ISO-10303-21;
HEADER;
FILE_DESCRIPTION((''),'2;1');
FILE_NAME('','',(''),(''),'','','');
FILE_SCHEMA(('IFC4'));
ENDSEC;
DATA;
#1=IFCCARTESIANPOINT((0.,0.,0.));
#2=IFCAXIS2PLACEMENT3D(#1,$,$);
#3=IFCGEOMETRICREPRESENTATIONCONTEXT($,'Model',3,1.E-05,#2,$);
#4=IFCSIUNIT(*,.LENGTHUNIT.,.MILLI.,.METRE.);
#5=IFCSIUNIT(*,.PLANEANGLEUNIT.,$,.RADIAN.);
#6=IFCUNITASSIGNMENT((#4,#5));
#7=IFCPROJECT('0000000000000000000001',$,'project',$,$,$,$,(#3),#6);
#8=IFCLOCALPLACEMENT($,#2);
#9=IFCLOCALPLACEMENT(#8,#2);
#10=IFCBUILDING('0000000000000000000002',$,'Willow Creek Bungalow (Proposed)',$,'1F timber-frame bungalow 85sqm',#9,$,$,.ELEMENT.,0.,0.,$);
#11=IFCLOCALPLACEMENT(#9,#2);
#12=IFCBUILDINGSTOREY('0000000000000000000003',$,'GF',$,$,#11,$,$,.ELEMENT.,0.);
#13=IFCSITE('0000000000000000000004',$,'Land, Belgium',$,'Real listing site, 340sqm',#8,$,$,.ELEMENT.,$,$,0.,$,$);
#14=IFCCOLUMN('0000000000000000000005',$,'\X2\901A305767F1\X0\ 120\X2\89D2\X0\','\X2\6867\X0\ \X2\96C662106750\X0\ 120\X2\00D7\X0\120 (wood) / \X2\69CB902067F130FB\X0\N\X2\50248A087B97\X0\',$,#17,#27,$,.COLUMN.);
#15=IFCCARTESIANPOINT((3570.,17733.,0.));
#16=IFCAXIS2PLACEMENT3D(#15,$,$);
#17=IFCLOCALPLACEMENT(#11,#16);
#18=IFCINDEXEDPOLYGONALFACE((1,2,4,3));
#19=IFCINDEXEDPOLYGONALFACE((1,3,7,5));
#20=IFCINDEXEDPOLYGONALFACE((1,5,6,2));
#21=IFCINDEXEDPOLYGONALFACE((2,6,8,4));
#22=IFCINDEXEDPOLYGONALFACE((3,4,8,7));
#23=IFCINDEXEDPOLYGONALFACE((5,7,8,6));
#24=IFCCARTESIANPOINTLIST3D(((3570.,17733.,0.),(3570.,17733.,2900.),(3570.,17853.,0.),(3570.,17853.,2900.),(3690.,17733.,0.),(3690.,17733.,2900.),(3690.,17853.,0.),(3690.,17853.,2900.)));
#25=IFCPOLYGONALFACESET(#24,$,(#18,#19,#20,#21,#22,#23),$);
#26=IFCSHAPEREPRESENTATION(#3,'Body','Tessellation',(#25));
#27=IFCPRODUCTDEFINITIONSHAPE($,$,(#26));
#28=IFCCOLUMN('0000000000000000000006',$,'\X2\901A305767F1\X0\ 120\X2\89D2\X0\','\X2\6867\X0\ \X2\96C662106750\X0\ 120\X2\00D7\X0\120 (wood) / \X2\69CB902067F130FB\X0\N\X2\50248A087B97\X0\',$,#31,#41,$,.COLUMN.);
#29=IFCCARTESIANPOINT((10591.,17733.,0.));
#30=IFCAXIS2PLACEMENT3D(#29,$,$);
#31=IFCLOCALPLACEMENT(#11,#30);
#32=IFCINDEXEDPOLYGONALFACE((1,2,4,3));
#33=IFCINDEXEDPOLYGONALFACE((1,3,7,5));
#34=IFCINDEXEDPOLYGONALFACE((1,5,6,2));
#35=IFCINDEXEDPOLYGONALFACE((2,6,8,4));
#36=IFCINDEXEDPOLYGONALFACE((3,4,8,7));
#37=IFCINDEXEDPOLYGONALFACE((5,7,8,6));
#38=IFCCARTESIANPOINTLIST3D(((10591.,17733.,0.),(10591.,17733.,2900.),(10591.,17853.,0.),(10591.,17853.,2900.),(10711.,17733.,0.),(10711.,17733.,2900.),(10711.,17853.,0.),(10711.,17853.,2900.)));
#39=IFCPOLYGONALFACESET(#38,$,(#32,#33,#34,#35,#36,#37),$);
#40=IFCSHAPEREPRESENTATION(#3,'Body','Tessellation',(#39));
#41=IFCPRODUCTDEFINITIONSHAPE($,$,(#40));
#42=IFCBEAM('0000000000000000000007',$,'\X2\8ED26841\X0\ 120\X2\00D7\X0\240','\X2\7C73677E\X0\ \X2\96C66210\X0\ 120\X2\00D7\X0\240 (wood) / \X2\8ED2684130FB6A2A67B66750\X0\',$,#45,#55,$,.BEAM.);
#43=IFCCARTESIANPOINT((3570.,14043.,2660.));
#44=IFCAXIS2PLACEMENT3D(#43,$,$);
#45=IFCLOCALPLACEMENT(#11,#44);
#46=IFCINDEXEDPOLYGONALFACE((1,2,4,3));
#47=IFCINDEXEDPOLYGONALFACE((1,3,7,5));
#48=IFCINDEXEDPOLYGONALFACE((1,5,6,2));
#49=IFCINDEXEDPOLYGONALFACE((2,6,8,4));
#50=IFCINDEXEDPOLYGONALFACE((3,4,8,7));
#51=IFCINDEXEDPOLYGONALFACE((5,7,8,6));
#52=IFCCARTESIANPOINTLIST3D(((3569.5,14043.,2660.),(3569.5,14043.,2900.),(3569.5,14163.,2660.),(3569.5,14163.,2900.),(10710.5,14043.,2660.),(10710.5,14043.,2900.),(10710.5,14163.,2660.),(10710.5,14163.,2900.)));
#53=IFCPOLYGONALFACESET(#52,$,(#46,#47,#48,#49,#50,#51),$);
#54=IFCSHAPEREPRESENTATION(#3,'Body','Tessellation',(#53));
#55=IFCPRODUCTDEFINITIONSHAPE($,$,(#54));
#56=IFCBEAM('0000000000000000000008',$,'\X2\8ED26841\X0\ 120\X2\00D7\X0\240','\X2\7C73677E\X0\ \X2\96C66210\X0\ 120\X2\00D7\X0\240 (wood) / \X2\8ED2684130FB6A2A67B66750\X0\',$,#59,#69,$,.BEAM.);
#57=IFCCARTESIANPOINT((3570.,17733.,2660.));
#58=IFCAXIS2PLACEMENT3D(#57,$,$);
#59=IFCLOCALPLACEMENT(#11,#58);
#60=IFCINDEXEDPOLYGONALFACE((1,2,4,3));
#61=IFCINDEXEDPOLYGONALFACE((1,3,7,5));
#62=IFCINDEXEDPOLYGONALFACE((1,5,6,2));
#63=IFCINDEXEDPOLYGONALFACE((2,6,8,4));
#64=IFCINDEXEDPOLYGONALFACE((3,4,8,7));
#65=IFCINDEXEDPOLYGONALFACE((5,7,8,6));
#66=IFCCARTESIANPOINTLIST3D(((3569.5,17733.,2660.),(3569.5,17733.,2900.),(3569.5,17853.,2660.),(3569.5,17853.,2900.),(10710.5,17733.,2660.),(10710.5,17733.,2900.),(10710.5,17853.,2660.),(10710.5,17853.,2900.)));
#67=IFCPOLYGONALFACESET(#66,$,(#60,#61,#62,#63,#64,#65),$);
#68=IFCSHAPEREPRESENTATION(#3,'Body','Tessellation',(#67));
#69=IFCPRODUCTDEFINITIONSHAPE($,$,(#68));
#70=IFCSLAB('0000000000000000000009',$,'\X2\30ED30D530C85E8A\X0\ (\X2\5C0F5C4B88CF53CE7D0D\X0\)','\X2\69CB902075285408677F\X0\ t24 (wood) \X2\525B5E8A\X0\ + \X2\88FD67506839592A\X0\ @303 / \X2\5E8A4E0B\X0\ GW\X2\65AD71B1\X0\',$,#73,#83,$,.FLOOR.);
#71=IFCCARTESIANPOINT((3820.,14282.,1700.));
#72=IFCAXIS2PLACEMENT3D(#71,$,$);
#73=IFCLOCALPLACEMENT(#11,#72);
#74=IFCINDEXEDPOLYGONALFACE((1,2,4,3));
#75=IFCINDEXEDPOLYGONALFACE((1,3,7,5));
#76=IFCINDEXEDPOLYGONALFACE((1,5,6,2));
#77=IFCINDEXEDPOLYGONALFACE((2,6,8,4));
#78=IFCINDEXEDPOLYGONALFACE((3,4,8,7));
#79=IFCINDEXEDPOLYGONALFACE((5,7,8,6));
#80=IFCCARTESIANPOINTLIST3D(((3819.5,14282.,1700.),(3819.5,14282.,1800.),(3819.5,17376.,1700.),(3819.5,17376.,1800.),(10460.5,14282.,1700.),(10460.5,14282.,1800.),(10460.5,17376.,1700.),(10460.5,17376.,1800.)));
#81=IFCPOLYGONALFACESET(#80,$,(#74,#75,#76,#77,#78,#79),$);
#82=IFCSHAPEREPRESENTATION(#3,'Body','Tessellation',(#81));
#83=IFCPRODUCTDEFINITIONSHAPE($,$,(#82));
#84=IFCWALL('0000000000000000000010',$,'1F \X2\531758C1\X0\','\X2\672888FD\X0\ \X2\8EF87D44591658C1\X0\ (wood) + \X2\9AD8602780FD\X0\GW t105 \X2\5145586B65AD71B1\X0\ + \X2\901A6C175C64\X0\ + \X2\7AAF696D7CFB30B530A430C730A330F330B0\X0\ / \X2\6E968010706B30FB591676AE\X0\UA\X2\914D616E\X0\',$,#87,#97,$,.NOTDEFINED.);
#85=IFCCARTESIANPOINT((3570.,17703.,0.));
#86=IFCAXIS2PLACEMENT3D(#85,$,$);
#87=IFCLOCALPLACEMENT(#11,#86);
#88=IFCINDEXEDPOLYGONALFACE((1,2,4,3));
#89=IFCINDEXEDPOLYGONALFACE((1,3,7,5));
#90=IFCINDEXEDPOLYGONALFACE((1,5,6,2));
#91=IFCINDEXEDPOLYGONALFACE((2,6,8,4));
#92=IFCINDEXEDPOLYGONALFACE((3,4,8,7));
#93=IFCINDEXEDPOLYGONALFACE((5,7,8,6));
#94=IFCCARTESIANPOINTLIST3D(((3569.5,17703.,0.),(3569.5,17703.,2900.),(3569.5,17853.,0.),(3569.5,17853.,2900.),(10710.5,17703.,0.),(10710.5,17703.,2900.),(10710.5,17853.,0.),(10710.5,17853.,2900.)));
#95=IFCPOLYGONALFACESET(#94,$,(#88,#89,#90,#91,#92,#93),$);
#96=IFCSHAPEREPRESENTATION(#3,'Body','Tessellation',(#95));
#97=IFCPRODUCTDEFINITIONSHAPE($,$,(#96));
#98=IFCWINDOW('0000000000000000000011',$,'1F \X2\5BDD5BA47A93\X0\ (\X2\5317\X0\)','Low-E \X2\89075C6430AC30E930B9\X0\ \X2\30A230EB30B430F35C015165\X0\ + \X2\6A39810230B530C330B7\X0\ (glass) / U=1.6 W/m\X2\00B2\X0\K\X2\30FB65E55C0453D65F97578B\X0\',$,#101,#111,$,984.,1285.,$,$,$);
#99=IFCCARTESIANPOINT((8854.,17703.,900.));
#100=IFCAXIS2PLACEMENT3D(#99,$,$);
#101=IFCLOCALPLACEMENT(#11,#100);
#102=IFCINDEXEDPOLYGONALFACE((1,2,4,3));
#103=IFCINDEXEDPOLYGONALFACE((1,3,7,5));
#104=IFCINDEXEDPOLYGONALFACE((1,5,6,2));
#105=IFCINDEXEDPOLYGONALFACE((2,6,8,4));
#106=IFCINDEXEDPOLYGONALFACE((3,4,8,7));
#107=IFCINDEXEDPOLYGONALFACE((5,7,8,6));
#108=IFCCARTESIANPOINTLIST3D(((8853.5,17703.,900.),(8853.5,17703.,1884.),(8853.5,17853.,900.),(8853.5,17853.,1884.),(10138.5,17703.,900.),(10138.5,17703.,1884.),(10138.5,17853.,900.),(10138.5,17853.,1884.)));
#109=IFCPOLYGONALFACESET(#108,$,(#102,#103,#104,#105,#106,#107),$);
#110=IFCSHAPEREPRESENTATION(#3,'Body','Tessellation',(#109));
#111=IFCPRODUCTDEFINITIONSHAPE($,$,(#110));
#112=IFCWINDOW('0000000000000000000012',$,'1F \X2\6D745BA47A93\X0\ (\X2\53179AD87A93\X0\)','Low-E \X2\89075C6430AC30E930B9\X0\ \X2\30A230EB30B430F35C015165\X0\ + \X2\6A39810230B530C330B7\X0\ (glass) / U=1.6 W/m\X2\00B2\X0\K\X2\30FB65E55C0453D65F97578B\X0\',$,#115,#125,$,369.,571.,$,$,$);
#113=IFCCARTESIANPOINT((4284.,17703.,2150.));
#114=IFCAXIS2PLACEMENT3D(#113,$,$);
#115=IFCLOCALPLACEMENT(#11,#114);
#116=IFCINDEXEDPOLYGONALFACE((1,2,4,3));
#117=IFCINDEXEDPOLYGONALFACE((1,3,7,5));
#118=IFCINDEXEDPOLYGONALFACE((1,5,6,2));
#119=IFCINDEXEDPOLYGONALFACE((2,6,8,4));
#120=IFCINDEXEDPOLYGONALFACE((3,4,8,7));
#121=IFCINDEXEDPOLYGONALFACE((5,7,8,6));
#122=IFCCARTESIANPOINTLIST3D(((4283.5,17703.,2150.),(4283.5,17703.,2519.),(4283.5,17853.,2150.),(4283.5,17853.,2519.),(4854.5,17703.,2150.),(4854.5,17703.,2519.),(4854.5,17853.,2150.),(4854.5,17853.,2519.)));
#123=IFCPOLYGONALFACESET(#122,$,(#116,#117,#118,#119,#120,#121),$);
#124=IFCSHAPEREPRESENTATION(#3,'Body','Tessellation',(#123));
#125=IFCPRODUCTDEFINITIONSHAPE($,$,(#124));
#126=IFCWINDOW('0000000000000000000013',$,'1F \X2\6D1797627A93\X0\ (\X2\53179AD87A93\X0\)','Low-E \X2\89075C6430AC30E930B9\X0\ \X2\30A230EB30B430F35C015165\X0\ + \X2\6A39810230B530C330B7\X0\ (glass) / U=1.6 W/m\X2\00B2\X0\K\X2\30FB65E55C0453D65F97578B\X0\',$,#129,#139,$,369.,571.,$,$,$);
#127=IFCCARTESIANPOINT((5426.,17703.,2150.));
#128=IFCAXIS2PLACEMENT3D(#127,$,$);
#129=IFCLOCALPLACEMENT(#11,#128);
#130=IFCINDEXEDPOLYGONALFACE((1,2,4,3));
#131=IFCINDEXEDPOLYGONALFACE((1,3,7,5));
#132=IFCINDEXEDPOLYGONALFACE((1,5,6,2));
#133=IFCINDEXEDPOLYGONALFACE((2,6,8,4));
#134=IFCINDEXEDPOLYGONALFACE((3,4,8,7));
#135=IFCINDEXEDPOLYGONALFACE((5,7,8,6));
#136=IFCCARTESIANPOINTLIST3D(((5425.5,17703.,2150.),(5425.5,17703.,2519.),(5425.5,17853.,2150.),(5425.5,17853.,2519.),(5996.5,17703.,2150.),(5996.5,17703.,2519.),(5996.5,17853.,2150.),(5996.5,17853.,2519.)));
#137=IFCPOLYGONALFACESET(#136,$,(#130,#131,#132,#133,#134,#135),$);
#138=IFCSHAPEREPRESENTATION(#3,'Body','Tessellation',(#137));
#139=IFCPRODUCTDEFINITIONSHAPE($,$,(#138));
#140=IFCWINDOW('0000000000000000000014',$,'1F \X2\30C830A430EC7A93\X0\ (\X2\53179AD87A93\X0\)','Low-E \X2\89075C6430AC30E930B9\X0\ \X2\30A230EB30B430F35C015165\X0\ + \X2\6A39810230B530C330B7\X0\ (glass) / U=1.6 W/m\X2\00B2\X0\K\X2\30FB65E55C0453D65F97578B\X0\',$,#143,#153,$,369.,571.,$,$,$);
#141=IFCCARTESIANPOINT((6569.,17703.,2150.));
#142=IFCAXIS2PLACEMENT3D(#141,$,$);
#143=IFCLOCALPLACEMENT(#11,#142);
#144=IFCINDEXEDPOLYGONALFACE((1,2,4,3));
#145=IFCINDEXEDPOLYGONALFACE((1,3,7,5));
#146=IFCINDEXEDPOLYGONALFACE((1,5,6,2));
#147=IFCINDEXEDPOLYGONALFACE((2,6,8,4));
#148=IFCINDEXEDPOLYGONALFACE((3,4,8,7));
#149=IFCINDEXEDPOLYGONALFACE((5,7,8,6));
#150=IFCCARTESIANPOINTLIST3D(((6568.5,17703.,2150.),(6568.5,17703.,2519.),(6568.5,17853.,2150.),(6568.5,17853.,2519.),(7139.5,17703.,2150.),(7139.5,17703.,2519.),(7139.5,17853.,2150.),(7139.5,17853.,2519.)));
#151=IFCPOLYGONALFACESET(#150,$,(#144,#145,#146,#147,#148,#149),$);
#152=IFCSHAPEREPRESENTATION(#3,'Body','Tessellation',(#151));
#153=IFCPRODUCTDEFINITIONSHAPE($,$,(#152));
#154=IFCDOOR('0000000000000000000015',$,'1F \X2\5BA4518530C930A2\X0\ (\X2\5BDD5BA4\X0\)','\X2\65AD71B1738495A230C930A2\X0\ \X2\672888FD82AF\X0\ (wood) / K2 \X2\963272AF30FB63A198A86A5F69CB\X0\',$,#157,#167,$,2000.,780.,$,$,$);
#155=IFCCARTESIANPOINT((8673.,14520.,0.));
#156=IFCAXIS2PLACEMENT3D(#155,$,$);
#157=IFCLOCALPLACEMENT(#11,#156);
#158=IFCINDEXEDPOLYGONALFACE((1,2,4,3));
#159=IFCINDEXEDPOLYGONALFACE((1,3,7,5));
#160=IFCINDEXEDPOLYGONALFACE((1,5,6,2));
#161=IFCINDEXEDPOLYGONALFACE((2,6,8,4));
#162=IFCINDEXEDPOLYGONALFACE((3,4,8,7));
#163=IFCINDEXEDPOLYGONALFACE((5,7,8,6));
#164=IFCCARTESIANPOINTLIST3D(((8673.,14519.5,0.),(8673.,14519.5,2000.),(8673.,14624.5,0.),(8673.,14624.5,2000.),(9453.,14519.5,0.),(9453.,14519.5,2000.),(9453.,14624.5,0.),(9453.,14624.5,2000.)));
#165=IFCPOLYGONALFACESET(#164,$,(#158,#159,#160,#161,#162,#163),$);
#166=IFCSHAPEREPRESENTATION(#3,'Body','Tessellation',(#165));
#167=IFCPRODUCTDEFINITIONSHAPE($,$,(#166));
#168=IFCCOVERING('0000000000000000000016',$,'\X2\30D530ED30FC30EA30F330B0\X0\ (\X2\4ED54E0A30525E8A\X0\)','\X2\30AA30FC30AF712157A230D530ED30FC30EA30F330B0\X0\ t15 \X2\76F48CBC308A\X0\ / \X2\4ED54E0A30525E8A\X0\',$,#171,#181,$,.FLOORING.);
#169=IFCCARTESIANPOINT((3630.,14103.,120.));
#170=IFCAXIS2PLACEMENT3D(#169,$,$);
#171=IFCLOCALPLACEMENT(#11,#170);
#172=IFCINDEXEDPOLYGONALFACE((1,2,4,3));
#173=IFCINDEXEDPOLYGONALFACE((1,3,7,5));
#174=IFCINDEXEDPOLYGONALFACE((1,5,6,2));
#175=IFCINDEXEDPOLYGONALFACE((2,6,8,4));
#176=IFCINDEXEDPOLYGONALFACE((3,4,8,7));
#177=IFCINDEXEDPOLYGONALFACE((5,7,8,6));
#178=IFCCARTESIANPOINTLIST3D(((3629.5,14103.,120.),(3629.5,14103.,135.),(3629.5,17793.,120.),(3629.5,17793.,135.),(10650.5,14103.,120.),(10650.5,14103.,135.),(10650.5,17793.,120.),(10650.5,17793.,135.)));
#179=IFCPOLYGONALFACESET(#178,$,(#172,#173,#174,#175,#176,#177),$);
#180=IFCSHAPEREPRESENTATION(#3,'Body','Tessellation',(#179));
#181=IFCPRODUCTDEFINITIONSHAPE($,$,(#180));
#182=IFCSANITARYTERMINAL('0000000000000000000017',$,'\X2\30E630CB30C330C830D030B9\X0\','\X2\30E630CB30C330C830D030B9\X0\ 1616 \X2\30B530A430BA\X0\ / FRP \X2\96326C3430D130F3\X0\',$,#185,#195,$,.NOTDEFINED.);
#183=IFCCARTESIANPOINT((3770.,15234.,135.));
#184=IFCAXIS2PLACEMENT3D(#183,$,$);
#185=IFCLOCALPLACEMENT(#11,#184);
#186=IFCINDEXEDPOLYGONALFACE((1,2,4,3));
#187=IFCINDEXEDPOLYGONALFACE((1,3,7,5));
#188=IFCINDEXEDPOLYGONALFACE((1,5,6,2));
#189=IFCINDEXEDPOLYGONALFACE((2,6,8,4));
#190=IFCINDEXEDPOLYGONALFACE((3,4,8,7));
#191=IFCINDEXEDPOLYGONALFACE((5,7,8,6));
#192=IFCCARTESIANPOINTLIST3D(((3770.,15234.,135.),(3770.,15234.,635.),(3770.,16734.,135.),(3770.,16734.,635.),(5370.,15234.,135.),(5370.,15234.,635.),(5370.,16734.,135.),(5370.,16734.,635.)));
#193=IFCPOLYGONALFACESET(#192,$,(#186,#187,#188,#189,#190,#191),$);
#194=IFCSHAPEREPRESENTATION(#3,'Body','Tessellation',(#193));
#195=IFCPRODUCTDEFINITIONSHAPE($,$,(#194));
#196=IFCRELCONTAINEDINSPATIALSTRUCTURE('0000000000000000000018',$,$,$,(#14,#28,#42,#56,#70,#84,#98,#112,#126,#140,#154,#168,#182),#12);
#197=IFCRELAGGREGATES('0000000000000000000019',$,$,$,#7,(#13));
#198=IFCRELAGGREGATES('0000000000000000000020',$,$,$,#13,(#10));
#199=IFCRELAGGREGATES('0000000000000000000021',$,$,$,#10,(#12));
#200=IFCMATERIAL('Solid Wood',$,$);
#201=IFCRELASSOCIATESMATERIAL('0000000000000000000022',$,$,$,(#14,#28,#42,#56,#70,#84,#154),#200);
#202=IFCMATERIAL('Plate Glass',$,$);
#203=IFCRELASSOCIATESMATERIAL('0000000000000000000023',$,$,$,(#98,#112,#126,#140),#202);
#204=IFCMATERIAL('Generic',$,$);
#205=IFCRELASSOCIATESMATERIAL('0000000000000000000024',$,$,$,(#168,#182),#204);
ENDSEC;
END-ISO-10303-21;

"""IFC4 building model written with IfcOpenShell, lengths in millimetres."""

from ifc_helpers import new_model, si_unit, frame, frame_2d, origin, place, context, project, spatial, rectangle, extrude, material, element, fill, save


model = new_model("IFC4")

# Units and contexts
model_context = context("Model", 3, precision=1e-05, world=origin())
ifc_project = project(units=[si_unit("LENGTHUNIT", "METRE", prefix="MILLI"), si_unit("PLANEANGLEUNIT", "RADIAN")], contexts=[model_context])

# Site, building, storey
site_placement = place(None, origin())
site = spatial("IfcSite", under=ifc_project, at=site_placement, Name="Land, Belgium", ObjectType="Real listing site, 340sqm", CompositionType="ELEMENT", RefElevation=0.0)
building_placement = place(site_placement, origin())
building = spatial("IfcBuilding", under=site, at=building_placement, Name="Willow Creek Bungalow (Proposed)", ObjectType="1F timber-frame bungalow 85sqm", CompositionType="ELEMENT", ElevationOfRefHeight=0.0, ElevationOfTerrain=0.0)
storey_placement = place(building_placement, origin())
storey = spatial("IfcBuildingStorey", under=building, at=storey_placement, Name="GF", CompositionType="ELEMENT", Elevation=0.0)

# Columns
ifc_material_1 = material(Name="Solid Wood")
column_1_placement = place(storey_placement, frame((3570.0, 17733.0, 0.0)))
element("IfcColumn", 1, at=column_1_placement, inside=storey, material=ifc_material_1, Name="通し柱 120角", Description="桧 集成材 120×120 (wood) / 構造柱・N値計算", PredefinedType="COLUMN", context=model_context, shape_type="SweptSolid", body=[
    extrude(rectangle(XDim=120.0, YDim=120.0, at=frame_2d((60.0, 60.0))), frame((3570.0, 17733.0, 0.0)), (0.0, 0.0, 1.0), 2900.0),
])
column_2_placement = place(storey_placement, frame((10591.0, 17733.0, 0.0)))
element("IfcColumn", 2, at=column_2_placement, inside=storey, material=ifc_material_1, Name="通し柱 120角", Description="桧 集成材 120×120 (wood) / 構造柱・N値計算", PredefinedType="COLUMN", context=model_context, shape_type="SweptSolid", body=[
    extrude(rectangle(XDim=120.0, YDim=120.0, at=frame_2d((60.0, 60.0))), frame((10591.0, 17733.0, 0.0)), (0.0, 0.0, 1.0), 2900.0),
])

# Beams
beam_1_placement = place(storey_placement, frame((3570.0, 14043.0, 2660.0)))
element("IfcBeam", 3, at=beam_1_placement, inside=storey, material=ifc_material_1, Name="軒桁 120×240", Description="米松 集成 120×240 (wood) / 軒桁・横架材", PredefinedType="BEAM", context=model_context, shape_type="SweptSolid", body=[
    extrude(rectangle(XDim=7141.0, YDim=120.0, at=frame_2d((3570.0, 60.0))), frame((3570.0, 14043.0, 2660.0)), (0.0, 0.0, 1.0), 240.0),
])
beam_2_placement = place(storey_placement, frame((3570.0, 17733.0, 2660.0)))
element("IfcBeam", 4, at=beam_2_placement, inside=storey, material=ifc_material_1, Name="軒桁 120×240", Description="米松 集成 120×240 (wood) / 軒桁・横架材", PredefinedType="BEAM", context=model_context, shape_type="SweptSolid", body=[
    extrude(rectangle(XDim=7141.0, YDim=120.0, at=frame_2d((3570.0, 60.0))), frame((3570.0, 17733.0, 2660.0)), (0.0, 0.0, 1.0), 240.0),
])

# Slab
slab_placement = place(storey_placement, frame((3820.0, 14282.0, 1700.0)))
element("IfcSlab", 5, at=slab_placement, inside=storey, material=ifc_material_1, Name="ロフト床 (小屋裏収納)", Description="構造用合板 t24 (wood) 剛床 + 製材根太 @303 / 床下 GW断熱", PredefinedType="FLOOR", context=model_context, shape_type="SweptSolid", body=[
    extrude(rectangle(XDim=6641.0, YDim=3094.0, at=frame_2d((3320.0, 1547.0))), frame((3820.0, 14282.0, 1700.0)), (0.0, 0.0, 1.0), 100.0),
])

# Wall, openings, windows
wall_1_placement = place(storey_placement, frame((3570.0, 17703.0, 0.0)))
wall_1 = element("IfcWall", 6, at=wall_1_placement, inside=storey, material=ifc_material_1, Name="1F 北壁", Description="木製 軸組外壁 (wood) + 高性能GW t105 充填断熱 + 通気層 + 窯業系サイディング / 準耐火・外皮UA配慮", PredefinedType="NOTDEFINED", context=model_context, shape_type="SweptSolid", body=[
    extrude(rectangle(XDim=7141.0, YDim=150.0, at=frame_2d((3570.0, 75.0))), frame((3570.0, 17703.0, 0.0)), (0.0, 0.0, 1.0), 2900.0),
])
opening_1_placement = place(storey_placement, frame((8854.0, 17703.0, 900.0)))
opening_1 = element("IfcOpeningElement", 7, at=opening_1_placement, cuts=wall_1, PredefinedType="NOTDEFINED", context=model_context, shape_type="SweptSolid", body=[
    extrude(rectangle(XDim=1285.0, YDim=150.0, at=frame_2d((642.0, 75.0))), frame((8854.0, 17703.0, 900.0)), (0.0, 0.0, 1.0), 984.0),
])
opening_2_placement = place(storey_placement, frame((4284.0, 17703.0, 2150.0)))
opening_2 = element("IfcOpeningElement", 8, at=opening_2_placement, cuts=wall_1, PredefinedType="NOTDEFINED", context=model_context, shape_type="SweptSolid", body=[
    extrude(rectangle(XDim=571.0, YDim=150.0, at=frame_2d((285.0, 75.0))), frame((4284.0, 17703.0, 2150.0)), (0.0, 0.0, 1.0), 369.0),
])
opening_3_placement = place(storey_placement, frame((5426.0, 17703.0, 2150.0)))
opening_3 = element("IfcOpeningElement", 9, at=opening_3_placement, cuts=wall_1, PredefinedType="NOTDEFINED", context=model_context, shape_type="SweptSolid", body=[
    extrude(rectangle(XDim=571.0, YDim=150.0, at=frame_2d((285.0, 75.0))), frame((5426.0, 17703.0, 2150.0)), (0.0, 0.0, 1.0), 369.0),
])
opening_4_placement = place(storey_placement, frame((6569.0, 17703.0, 2150.0)))
opening_4 = element("IfcOpeningElement", 10, at=opening_4_placement, cuts=wall_1, PredefinedType="NOTDEFINED", context=model_context, shape_type="SweptSolid", body=[
    extrude(rectangle(XDim=571.0, YDim=150.0, at=frame_2d((285.0, 75.0))), frame((6569.0, 17703.0, 2150.0)), (0.0, 0.0, 1.0), 369.0),
])
ifc_material_2 = material(Name="Plate Glass")
window_1_placement = place(storey_placement, frame((8854.0, 17703.0, 900.0)))
window_1 = element("IfcWindow", 11, at=window_1_placement, inside=storey, material=ifc_material_2, Name="1F 寝室窓 (北)", Description="Low-E 複層ガラス アルゴン封入 + 樹脂サッシ (glass) / U=1.6 W/m²K・日射取得型", OverallHeight=984.0, OverallWidth=1285.0, context=model_context, shape_type="SweptSolid", body=[
    extrude(rectangle(XDim=1285.0, YDim=150.0, at=frame_2d((642.0, 75.0))), frame((8854.0, 17703.0, 900.0)), (0.0, 0.0, 1.0), 984.0),
])
fill(opening_1, window_1)
window_2_placement = place(storey_placement, frame((4284.0, 17703.0, 2150.0)))
window_2 = element("IfcWindow", 12, at=window_2_placement, inside=storey, material=ifc_material_2, Name="1F 浴室窓 (北高窓)", Description="Low-E 複層ガラス アルゴン封入 + 樹脂サッシ (glass) / U=1.6 W/m²K・日射取得型", OverallHeight=369.0, OverallWidth=571.0, context=model_context, shape_type="SweptSolid", body=[
    extrude(rectangle(XDim=571.0, YDim=150.0, at=frame_2d((285.0, 75.0))), frame((4284.0, 17703.0, 2150.0)), (0.0, 0.0, 1.0), 369.0),
])
fill(opening_2, window_2)
window_3_placement = place(storey_placement, frame((5426.0, 17703.0, 2150.0)))
window_3 = element("IfcWindow", 13, at=window_3_placement, inside=storey, material=ifc_material_2, Name="1F 洗面窓 (北高窓)", Description="Low-E 複層ガラス アルゴン封入 + 樹脂サッシ (glass) / U=1.6 W/m²K・日射取得型", OverallHeight=369.0, OverallWidth=571.0, context=model_context, shape_type="SweptSolid", body=[
    extrude(rectangle(XDim=571.0, YDim=150.0, at=frame_2d((285.0, 75.0))), frame((5426.0, 17703.0, 2150.0)), (0.0, 0.0, 1.0), 369.0),
])
fill(opening_3, window_3)
window_4_placement = place(storey_placement, frame((6569.0, 17703.0, 2150.0)))
window_4 = element("IfcWindow", 14, at=window_4_placement, inside=storey, material=ifc_material_2, Name="1F トイレ窓 (北高窓)", Description="Low-E 複層ガラス アルゴン封入 + 樹脂サッシ (glass) / U=1.6 W/m²K・日射取得型", OverallHeight=369.0, OverallWidth=571.0, context=model_context, shape_type="SweptSolid", body=[
    extrude(rectangle(XDim=571.0, YDim=150.0, at=frame_2d((285.0, 75.0))), frame((6569.0, 17703.0, 2150.0)), (0.0, 0.0, 1.0), 369.0),
])
fill(opening_4, window_4)

# Door
door_1_placement = place(storey_placement, frame((8673.0, 14520.0, 0.0)))
element("IfcDoor", 15, at=door_1_placement, inside=storey, material=ifc_material_1, Name="1F 室内ドア (寝室)", Description="断熱玄関ドア 木製芯 (wood) / K2 防犯・採風機構", OverallHeight=2000.0, OverallWidth=780.0, context=model_context, shape_type="SweptSolid", body=[
    extrude(rectangle(XDim=780.0, YDim=105.0, at=frame_2d((390.0, 52.0))), frame((8673.0, 14520.0, 0.0)), (0.0, 0.0, 1.0), 2000.0),
])

# Covering
ifc_material_3 = material(Name="Generic")
covering_placement = place(storey_placement, frame((3630.0, 14103.0, 120.0)))
element("IfcCovering", 16, at=covering_placement, inside=storey, material=ifc_material_3, Name="フローリング (仕上げ床)", Description="オーク無垢フローリング t15 直貼り / 仕上げ床", PredefinedType="FLOORING", context=model_context, shape_type="SweptSolid", body=[
    extrude(rectangle(XDim=7021.0, YDim=3690.0, at=frame_2d((3510.0, 1845.0))), frame((3630.0, 14103.0, 120.0)), (0.0, 0.0, 1.0), 15.0),
])

# Sanitary terminal
sanitary_terminal_1_placement = place(storey_placement, frame((3770.0, 15234.0, 135.0)))
element("IfcSanitaryTerminal", 17, at=sanitary_terminal_1_placement, inside=storey, material=ifc_material_3, Name="ユニットバス", Description="ユニットバス 1616 サイズ / FRP 防水パン", PredefinedType="NOTDEFINED", context=model_context, shape_type="SweptSolid", body=[
    extrude(rectangle(XDim=1600.0, YDim=1500.0, at=frame_2d((800.0, 750.0))), frame((3770.0, 15234.0, 135.0)), (0.0, 0.0, 1.0), 500.0),
])

save(model, "model.ifc")
